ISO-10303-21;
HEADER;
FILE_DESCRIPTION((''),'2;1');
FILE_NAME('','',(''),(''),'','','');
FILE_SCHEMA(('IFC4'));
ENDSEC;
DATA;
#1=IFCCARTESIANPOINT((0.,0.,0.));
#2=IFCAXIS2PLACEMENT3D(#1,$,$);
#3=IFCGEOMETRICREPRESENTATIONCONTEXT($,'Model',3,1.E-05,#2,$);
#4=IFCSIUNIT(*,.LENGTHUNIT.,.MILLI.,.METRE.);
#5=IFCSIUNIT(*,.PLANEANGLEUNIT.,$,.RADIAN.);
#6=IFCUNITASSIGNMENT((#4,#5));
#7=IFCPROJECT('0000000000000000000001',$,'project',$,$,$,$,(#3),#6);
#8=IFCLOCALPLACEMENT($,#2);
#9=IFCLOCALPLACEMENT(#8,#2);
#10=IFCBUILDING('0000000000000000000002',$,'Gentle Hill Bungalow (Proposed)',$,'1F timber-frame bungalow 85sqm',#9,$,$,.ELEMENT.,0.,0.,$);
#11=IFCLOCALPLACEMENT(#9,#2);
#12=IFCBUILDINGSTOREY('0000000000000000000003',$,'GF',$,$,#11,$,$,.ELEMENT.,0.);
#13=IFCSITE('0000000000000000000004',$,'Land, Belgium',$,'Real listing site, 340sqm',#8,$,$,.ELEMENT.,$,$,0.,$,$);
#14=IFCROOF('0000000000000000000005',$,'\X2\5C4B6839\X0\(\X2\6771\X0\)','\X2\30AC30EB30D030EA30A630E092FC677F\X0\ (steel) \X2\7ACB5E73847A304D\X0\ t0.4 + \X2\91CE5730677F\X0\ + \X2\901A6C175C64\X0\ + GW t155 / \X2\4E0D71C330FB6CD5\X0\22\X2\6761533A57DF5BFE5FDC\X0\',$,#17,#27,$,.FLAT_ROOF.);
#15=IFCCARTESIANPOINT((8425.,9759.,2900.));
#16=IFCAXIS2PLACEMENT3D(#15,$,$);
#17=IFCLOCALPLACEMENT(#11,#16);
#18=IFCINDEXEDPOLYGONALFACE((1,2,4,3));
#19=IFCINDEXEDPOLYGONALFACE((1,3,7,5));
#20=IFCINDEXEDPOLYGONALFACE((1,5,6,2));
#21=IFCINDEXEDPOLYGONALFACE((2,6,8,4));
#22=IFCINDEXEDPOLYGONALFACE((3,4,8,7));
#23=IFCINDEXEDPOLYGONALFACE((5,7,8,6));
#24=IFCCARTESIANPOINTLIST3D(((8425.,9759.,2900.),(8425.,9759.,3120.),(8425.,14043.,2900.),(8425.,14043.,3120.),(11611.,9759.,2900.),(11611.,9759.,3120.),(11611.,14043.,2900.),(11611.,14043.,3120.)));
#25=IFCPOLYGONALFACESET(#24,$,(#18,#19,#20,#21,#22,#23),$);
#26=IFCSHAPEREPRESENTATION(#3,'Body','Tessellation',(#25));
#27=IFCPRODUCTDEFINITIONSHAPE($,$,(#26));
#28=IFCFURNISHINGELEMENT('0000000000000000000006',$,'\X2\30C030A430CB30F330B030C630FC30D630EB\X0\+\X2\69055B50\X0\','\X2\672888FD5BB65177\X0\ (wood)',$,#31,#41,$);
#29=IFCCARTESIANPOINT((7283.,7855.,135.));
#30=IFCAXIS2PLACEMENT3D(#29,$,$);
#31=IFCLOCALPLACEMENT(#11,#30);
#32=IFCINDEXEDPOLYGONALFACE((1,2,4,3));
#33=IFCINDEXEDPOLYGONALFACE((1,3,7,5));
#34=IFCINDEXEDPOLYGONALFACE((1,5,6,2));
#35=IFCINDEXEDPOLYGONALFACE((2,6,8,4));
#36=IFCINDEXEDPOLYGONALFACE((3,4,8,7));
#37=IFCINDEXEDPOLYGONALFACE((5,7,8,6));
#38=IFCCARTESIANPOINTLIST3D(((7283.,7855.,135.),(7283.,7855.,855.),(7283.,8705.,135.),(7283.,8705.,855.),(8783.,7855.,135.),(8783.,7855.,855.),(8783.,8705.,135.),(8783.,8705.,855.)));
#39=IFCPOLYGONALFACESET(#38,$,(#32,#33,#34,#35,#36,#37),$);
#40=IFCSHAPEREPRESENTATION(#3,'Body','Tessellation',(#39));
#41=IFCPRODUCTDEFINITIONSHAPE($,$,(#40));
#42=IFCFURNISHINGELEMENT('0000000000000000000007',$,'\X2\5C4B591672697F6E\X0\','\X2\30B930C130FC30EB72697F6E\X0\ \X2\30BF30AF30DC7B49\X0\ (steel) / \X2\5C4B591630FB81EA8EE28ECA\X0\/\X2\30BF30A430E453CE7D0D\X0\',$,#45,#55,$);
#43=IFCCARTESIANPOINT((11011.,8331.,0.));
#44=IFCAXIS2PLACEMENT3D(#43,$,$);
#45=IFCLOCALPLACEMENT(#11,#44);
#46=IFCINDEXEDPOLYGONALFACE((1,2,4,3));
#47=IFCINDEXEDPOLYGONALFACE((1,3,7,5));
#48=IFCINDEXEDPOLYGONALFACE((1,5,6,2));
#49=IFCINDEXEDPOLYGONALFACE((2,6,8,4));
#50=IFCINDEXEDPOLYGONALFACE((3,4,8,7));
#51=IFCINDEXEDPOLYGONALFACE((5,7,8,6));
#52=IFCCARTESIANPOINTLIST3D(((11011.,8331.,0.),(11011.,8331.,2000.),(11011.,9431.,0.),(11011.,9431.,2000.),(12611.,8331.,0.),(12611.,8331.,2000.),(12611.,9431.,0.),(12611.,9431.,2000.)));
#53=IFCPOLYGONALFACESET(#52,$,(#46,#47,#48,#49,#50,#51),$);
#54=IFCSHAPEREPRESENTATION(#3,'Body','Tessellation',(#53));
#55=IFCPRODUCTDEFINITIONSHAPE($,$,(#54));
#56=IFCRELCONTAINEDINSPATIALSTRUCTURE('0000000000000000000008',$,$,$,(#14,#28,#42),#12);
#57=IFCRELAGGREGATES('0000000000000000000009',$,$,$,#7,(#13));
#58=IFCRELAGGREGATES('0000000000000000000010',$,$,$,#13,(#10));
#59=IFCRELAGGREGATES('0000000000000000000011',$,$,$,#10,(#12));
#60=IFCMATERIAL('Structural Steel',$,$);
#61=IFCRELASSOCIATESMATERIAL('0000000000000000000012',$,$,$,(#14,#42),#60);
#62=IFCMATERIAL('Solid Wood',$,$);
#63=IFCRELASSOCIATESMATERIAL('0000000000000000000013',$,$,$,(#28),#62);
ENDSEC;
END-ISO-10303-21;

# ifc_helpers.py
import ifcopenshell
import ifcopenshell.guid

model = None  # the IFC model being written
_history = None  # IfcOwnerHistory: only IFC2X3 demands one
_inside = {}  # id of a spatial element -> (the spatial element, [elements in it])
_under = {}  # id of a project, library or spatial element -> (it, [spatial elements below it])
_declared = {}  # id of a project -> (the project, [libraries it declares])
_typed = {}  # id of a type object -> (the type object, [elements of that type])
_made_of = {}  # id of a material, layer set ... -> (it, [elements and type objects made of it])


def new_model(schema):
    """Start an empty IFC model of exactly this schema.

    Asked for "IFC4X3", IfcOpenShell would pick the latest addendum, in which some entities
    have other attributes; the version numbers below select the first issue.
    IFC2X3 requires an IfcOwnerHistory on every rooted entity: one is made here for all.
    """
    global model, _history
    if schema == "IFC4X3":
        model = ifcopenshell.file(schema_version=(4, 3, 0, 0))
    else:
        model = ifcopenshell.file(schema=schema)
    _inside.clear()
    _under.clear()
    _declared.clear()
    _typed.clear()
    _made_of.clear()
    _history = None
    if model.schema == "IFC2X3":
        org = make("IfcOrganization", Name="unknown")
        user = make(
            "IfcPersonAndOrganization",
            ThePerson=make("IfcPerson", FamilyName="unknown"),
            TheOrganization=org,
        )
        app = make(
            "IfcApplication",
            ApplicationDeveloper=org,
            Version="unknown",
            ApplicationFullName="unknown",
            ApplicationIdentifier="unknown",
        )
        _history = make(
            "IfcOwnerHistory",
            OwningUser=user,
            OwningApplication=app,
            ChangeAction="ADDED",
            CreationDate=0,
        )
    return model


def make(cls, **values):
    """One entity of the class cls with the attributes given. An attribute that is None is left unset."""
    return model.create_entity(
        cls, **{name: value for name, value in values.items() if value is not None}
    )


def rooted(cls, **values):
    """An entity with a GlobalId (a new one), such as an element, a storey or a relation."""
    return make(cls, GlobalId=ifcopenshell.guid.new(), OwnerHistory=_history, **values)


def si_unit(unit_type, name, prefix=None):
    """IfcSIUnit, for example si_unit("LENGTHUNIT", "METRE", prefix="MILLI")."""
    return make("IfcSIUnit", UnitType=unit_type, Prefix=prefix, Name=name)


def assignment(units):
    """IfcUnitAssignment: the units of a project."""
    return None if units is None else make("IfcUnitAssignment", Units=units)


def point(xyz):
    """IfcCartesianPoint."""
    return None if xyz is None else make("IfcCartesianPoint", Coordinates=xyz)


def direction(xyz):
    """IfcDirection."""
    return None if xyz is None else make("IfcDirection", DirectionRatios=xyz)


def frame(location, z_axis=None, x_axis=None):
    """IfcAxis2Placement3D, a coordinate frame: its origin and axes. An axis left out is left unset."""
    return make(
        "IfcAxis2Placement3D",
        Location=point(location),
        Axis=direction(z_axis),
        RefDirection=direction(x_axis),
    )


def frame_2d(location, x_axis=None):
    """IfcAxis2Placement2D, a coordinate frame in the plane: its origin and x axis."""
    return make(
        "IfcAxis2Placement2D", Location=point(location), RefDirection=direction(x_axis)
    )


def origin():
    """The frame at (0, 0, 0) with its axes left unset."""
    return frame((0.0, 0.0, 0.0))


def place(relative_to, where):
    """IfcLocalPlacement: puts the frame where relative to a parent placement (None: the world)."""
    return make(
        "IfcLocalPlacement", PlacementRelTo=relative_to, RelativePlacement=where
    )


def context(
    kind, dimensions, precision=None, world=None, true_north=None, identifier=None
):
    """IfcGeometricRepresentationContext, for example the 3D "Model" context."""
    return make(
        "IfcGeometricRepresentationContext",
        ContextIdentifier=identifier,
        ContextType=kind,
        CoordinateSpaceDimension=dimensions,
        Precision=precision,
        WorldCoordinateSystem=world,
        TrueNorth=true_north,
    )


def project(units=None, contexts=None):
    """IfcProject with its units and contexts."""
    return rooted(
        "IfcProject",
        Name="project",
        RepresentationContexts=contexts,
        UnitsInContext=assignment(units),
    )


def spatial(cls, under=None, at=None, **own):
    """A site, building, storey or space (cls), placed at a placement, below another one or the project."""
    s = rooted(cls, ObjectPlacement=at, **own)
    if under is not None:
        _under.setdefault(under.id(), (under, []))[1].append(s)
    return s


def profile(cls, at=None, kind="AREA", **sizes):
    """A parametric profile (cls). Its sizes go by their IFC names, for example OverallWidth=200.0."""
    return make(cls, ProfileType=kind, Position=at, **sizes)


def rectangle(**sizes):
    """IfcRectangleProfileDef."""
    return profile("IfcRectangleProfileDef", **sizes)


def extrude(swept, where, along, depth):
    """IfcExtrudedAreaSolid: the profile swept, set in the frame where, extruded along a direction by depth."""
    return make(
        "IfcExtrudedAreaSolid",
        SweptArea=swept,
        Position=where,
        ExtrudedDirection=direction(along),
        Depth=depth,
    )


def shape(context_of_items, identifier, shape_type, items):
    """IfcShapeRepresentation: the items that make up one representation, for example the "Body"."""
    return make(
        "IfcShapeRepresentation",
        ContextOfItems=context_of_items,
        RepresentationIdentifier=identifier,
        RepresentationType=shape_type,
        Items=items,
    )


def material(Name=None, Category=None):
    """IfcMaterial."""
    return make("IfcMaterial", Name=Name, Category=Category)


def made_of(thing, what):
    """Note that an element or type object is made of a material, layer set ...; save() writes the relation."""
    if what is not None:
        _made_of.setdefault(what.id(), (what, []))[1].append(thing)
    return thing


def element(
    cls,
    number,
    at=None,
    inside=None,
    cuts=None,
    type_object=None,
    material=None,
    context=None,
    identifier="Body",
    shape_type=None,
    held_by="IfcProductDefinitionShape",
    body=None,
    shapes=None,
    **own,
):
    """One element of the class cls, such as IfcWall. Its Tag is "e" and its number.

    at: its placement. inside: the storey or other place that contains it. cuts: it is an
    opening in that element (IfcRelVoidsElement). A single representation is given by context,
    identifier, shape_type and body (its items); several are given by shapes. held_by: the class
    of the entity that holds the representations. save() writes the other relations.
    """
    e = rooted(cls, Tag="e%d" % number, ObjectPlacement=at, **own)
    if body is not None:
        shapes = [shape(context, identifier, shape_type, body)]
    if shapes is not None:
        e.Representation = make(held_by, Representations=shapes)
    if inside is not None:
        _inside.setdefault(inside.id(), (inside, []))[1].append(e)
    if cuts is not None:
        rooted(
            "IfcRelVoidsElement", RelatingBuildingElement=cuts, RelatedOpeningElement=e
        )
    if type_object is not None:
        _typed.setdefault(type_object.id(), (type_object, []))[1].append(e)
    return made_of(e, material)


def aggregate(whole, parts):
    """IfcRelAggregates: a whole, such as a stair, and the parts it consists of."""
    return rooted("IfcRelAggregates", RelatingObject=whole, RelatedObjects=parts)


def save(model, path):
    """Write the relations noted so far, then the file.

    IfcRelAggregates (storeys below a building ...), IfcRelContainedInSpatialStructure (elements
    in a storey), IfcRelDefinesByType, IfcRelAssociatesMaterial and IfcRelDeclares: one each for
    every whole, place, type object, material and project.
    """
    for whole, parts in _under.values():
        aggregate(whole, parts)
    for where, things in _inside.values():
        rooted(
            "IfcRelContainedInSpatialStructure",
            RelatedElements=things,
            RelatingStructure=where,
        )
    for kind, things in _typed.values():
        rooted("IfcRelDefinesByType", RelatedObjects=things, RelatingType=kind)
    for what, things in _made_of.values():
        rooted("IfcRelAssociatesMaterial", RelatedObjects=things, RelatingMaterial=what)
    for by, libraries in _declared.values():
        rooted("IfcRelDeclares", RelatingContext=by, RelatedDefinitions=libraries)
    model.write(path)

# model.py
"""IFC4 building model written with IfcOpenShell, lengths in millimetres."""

from ifc_helpers import new_model, si_unit, frame, frame_2d, origin, place, context, project, spatial, rectangle, extrude, material, element, save


model = new_model("IFC4")

# Units and contexts
model_context = context("Model", 3, precision=1e-05, world=origin())
ifc_project = project(units=[si_unit("LENGTHUNIT", "METRE", prefix="MILLI"), si_unit("PLANEANGLEUNIT", "RADIAN")], contexts=[model_context])

# Site, building, storey
site_placement = place(None, origin())
site = spatial("IfcSite", under=ifc_project, at=site_placement, Name="Land, Belgium", ObjectType="Real listing site, 340sqm", CompositionType="ELEMENT", RefElevation=0.0)
building_placement = place(site_placement, origin())
building = spatial("IfcBuilding", under=site, at=building_placement, Name="Gentle Hill Bungalow (Proposed)", ObjectType="1F timber-frame bungalow 85sqm", CompositionType="ELEMENT", ElevationOfRefHeight=0.0, ElevationOfTerrain=0.0)
storey_placement = place(building_placement, origin())
storey = spatial("IfcBuildingStorey", under=building, at=storey_placement, Name="GF", CompositionType="ELEMENT", Elevation=0.0)

# Shared definitions
ifc_material_1 = material(Name="Solid Wood")

# Roof
ifc_material_2 = material(Name="Structural Steel")
roof_1_placement = place(storey_placement, frame((8425.0, 9759.0, 2900.0)))
element("IfcRoof", 1, at=roof_1_placement, inside=storey, material=ifc_material_2, Name="屋根(東)", Description="ガルバリウム鋼板 (steel) 立平葺き t0.4 + 野地板 + 通気層 + GW t155 / 不燃・法22条区域対応", PredefinedType="FLAT_ROOF", context=model_context, shape_type="SweptSolid", body=[
    extrude(rectangle(XDim=3186.0, YDim=4284.0, at=frame_2d((1593.0, 2142.0))), frame((8425.0, 9759.0, 2900.0)), (0.0, 0.0, 1.0), 220.0),
])

# Furnishing elements
furnishing_1_placement = place(storey_placement, frame((7283.0, 7855.0, 135.0)))
element("IfcFurnishingElement", 2, at=furnishing_1_placement, inside=storey, material=ifc_material_1, Name="ダイニングテーブル+椅子", Description="木製家具 (wood)", context=model_context, shape_type="SweptSolid", body=[
    extrude(rectangle(XDim=1500.0, YDim=850.0, at=frame_2d((750.0, 425.0))), frame((7283.0, 7855.0, 135.0)), (0.0, 0.0, 1.0), 720.0),
])
furnishing_2_placement = place(storey_placement, frame((11011.0, 8331.0, 0.0)))
element("IfcFurnishingElement", 3, at=furnishing_2_placement, inside=storey, material=ifc_material_2, Name="屋外物置", Description="スチール物置 タクボ等 (steel) / 屋外・自転車/タイヤ収納", context=model_context, shape_type="SweptSolid", body=[
    extrude(rectangle(XDim=1600.0, YDim=1100.0, at=frame_2d((800.0, 550.0))), frame((11011.0, 8331.0, 0.0)), (0.0, 0.0, 1.0), 2000.0),
])

save(model, "model.ifc")
